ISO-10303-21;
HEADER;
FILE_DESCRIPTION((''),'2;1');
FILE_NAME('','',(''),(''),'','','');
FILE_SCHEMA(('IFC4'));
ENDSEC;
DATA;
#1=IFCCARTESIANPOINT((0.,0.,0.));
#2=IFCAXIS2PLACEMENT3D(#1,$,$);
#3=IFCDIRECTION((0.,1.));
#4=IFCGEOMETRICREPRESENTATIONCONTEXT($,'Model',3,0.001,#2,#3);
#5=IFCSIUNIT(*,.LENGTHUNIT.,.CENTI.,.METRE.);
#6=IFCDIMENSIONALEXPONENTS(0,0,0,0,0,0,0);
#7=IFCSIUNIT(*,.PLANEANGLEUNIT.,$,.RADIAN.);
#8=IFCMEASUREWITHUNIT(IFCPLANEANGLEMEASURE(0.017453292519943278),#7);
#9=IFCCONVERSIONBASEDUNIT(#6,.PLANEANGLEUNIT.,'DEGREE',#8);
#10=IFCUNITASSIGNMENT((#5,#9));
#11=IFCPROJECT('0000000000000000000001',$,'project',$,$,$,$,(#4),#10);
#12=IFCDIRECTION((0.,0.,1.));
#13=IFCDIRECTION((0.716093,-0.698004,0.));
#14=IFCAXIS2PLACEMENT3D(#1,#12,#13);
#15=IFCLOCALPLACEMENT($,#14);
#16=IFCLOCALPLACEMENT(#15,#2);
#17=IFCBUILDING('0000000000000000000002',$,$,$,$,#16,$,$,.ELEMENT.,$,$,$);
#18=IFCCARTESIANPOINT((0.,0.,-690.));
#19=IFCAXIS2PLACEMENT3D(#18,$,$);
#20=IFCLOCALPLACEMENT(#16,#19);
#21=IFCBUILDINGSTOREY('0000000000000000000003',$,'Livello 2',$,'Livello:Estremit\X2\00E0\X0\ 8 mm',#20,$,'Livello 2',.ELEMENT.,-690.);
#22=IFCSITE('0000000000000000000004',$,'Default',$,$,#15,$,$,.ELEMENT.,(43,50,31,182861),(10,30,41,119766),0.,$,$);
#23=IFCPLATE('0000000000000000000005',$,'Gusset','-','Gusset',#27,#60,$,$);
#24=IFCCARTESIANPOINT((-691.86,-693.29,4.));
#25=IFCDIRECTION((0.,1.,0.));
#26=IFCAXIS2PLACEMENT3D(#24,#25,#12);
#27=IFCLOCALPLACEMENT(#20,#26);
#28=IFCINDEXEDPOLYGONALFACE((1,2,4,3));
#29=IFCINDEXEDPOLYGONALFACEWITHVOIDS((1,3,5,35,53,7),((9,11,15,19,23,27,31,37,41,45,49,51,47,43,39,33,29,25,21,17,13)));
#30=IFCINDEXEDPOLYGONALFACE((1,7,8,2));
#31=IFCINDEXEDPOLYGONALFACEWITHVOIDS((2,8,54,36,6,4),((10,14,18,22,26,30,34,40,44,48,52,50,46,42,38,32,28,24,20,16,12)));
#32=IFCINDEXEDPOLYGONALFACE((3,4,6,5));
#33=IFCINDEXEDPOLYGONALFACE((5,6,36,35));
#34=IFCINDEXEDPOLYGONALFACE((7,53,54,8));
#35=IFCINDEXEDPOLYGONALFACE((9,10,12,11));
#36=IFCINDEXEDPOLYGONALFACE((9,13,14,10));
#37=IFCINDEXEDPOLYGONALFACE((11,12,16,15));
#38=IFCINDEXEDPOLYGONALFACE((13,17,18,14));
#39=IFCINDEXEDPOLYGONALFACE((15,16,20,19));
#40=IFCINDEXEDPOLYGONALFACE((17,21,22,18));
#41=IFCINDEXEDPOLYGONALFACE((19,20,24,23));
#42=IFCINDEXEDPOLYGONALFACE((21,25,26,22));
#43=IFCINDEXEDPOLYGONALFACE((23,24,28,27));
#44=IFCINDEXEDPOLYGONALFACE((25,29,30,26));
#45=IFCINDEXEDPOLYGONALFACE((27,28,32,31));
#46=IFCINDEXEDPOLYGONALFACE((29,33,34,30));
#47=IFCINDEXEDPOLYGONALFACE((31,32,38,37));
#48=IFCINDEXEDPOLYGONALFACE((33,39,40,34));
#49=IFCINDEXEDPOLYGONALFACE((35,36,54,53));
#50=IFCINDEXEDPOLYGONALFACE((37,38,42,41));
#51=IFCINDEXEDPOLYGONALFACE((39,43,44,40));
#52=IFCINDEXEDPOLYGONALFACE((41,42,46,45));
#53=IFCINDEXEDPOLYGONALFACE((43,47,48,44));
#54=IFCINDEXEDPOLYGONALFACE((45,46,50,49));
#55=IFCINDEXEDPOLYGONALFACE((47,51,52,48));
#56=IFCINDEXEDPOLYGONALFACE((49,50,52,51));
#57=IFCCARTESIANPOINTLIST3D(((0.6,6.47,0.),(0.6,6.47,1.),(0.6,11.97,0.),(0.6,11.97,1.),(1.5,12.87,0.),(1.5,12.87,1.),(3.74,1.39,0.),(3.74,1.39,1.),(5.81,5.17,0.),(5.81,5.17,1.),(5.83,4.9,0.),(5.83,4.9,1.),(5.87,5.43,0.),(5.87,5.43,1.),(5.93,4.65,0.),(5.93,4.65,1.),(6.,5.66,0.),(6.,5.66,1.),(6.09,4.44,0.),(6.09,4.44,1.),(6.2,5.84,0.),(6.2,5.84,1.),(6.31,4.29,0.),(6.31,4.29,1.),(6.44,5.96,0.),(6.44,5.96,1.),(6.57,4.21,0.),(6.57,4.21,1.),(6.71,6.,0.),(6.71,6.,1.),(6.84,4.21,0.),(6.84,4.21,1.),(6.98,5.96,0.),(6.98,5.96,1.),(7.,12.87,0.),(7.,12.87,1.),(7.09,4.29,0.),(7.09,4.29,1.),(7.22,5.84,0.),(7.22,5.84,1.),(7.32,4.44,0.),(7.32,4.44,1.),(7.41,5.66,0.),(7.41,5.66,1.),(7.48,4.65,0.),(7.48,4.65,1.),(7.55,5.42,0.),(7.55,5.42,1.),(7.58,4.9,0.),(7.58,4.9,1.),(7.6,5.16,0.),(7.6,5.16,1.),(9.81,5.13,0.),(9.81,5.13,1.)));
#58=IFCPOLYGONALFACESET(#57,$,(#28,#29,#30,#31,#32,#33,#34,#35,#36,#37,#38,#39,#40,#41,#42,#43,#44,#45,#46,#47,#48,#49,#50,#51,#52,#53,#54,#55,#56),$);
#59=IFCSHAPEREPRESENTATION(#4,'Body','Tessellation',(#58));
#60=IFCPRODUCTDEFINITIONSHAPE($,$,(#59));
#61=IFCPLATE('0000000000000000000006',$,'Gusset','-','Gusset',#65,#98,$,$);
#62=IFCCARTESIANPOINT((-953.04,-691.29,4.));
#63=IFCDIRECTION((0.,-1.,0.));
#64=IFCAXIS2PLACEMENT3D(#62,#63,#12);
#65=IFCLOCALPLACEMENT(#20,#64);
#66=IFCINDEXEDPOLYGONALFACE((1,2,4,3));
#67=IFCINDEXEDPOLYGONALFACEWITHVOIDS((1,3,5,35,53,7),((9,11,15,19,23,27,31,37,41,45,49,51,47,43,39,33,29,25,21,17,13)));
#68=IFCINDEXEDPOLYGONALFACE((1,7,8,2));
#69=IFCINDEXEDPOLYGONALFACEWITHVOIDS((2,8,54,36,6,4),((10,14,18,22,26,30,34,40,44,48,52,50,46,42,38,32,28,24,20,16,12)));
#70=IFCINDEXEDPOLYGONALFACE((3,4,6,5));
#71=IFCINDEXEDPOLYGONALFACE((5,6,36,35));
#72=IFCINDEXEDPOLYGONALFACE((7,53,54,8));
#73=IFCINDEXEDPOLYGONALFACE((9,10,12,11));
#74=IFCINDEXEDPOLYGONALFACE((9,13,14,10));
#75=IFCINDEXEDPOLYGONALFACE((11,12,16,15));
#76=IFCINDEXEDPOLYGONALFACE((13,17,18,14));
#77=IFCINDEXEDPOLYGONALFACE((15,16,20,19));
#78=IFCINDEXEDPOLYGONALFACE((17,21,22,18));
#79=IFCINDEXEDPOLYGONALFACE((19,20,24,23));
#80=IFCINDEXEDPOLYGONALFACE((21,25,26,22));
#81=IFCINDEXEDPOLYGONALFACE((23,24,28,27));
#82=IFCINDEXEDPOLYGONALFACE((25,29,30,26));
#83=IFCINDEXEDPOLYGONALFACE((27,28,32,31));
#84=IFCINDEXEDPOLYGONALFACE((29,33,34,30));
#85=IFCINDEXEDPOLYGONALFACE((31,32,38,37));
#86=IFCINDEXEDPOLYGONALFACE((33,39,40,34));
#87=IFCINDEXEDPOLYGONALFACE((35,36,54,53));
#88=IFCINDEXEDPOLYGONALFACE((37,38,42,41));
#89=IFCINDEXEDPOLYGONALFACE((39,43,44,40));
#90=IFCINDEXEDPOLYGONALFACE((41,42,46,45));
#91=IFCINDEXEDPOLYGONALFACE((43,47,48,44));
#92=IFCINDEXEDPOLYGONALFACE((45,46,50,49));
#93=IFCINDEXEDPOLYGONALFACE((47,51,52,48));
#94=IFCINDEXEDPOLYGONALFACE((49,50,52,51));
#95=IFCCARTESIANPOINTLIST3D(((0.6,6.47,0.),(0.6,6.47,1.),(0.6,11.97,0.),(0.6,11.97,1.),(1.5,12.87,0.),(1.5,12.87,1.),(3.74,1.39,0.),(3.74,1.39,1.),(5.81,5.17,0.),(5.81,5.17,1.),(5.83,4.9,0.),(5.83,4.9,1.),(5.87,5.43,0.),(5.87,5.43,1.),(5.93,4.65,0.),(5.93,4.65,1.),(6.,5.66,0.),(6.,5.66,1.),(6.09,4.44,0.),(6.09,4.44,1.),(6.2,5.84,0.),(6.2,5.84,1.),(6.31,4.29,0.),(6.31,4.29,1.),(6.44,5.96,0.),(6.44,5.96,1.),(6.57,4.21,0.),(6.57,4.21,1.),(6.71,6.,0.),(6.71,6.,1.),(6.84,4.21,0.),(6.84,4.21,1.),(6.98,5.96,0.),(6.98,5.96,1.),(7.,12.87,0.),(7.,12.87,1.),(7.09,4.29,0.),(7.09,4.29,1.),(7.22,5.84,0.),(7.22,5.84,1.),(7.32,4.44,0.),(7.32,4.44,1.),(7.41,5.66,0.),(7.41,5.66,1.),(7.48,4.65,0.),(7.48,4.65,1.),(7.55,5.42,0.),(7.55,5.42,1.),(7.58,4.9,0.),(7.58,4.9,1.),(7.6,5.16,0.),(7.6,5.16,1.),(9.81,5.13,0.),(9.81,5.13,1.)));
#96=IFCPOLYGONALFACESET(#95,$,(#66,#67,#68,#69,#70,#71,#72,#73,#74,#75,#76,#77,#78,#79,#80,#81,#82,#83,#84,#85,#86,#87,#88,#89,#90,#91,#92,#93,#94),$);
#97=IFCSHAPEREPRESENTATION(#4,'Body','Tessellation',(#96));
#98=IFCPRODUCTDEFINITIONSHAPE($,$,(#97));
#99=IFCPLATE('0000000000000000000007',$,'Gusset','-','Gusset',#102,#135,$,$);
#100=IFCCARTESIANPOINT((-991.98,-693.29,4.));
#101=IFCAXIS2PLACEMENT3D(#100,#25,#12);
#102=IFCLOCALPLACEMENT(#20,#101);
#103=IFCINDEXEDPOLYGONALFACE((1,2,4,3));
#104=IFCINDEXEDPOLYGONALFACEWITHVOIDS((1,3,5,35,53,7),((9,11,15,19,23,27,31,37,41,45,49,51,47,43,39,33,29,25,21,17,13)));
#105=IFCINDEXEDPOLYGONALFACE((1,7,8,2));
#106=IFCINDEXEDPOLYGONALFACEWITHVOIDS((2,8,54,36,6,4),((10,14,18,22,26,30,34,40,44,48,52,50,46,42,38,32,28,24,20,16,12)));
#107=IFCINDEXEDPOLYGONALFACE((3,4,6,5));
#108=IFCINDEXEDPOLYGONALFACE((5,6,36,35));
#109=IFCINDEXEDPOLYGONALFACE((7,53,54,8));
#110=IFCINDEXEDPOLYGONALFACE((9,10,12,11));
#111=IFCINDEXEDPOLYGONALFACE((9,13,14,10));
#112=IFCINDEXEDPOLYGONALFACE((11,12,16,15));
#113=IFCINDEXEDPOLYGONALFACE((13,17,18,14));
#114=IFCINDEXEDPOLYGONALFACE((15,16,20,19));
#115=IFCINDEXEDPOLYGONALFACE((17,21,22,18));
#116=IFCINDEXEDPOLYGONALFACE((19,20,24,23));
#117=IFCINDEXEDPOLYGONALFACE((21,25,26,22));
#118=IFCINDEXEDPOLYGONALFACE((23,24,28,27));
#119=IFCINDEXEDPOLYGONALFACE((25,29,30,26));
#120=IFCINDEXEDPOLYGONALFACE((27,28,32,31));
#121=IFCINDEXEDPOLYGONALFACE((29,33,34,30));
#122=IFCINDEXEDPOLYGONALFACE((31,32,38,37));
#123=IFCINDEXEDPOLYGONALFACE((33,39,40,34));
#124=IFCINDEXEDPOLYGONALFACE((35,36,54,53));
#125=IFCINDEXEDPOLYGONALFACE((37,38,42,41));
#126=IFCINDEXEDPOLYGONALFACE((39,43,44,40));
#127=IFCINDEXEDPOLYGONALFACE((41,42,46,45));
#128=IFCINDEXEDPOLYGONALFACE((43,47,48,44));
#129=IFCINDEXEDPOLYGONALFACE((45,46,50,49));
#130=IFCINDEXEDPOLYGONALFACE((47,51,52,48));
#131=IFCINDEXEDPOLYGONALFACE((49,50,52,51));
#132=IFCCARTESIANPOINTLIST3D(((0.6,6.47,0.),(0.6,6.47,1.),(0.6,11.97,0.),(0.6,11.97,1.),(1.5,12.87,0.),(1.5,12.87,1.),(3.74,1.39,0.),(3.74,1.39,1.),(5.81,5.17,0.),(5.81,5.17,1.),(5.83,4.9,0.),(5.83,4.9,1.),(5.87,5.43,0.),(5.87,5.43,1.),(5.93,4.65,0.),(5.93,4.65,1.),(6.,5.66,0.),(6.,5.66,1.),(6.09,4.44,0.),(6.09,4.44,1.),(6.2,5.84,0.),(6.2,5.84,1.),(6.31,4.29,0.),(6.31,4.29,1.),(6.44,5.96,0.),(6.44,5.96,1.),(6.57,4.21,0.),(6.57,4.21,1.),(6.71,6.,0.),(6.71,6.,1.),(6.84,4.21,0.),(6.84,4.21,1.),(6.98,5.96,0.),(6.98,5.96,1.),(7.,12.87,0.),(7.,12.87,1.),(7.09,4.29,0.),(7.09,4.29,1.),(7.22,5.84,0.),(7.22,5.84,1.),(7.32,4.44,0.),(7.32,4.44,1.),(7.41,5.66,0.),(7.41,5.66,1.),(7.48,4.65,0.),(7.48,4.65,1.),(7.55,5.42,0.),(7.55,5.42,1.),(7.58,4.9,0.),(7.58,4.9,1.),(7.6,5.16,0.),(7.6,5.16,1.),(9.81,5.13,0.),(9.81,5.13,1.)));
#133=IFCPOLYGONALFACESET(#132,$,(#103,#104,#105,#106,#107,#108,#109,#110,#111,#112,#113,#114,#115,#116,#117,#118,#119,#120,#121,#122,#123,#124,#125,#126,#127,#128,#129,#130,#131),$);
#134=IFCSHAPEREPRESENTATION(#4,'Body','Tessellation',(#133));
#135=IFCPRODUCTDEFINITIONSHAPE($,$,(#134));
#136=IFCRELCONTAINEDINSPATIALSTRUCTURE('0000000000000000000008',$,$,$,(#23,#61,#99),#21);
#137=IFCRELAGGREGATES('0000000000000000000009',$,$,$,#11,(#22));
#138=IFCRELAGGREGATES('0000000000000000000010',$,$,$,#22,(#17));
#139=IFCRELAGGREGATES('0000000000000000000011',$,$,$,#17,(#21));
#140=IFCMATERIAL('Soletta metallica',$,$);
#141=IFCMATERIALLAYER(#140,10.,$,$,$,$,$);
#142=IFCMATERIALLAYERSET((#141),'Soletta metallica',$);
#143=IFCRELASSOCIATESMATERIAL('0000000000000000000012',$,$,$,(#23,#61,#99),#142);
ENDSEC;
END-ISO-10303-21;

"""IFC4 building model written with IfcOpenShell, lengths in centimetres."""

from ifc_helpers import new_model, entity, si_unit, converted_unit, point, direction, frame, frame_2d, origin, origin_with_axes, origin_2d_with_axis, place, context, project, spatial, polyline, circle_curve, line_curve, trimmed, segment, composite_curve, circle, outline, extrude, material, layer, layer_set, element, save


model = new_model("IFC4")

# Units and contexts
model_context = context("Model", 3, precision=0.001, world=origin(), true_north=direction((0.0, 1.0)))
ifc_project = project(units=[si_unit("LENGTHUNIT", "METRE", prefix="CENTI"), converted_unit("PLANEANGLEUNIT", "DEGREE", entity("IfcPlaneAngleMeasure", 0.017453292519943278), si_unit("PLANEANGLEUNIT", "RADIAN"), dimensions=[0, 0, 0, 0, 0, 0, 0])], contexts=[model_context])

# Site, building, storey
site_placement = place(None, frame((0.0, 0.0, 0.0), z_axis=(0.0, 0.0, 1.0), x_axis=(0.716093, -0.698004, 0.0)))
site = spatial("IfcSite", under=ifc_project, at=site_placement, Name="Default", CompositionType="ELEMENT", RefLatitude=(43, 50, 31, 182861), RefLongitude=(10, 30, 41, 119766), RefElevation=0.0)
building_placement = place(site_placement, origin())
building = spatial("IfcBuilding", under=site, at=building_placement, CompositionType="ELEMENT")
storey_placement = place(building_placement, frame((0.0, 0.0, -690.0)))
storey = spatial("IfcBuildingStorey", under=building, at=storey_placement, Name="Livello 2", ObjectType="Livello:Estremità 8 mm", LongName="Livello 2", CompositionType="ELEMENT", Elevation=-690.0)

# Plates, openings
ifc_material_1 = material(Name="Soletta metallica")
ifc_layer = layer(ifc_material_1, 10.0)
ifc_layer_set = layer_set([ifc_layer], Name="Soletta metallica")
plate_1_placement = place(storey_placement, frame((-691.86, -693.29, 4.0), z_axis=(0.0, 1.0, 0.0), x_axis=(0.0, 0.0, 1.0)))
plate_1 = element("IfcPlate", 1, at=plate_1_placement, inside=storey, material=ifc_layer_set, Name="Gusset", Description="-", ObjectType="Gusset", context=model_context, shape_type="SweptSolid", body=[
    extrude(outline(polyline([(0.6, 6.47), (3.74, 1.39), (9.81, 5.13), (7.0, 12.87), (0.6, 12.87), (0.6, 6.47)])), origin_with_axes(), (0.0, 0.0, 1.0), 1.0),
])
opening_1_placement = place(plate_1_placement, frame((0.0, 0.0, 0.0), z_axis=(0.0, 0.0, 1.0), x_axis=(1.0, 0.0, 0.0)))
element("IfcOpeningElement", 2, at=opening_1_placement, cuts=plate_1, ObjectType="Opening", context=model_context, shape_type="SweptSolid", body=[
    extrude(outline(composite_curve([segment(trimmed(line_curve((0.6, 12.87), (0.0, -1.0), 0.9), [point((0.6, 12.87))], [point((0.6, 11.97))], True, "CARTESIAN"), True, "CONTINUOUS"), segment(trimmed(circle_curve(frame_2d((1.5, 11.97), x_axis=(-1.0, 0.0)), 0.9), [point((0.6, 11.97))], [point((1.5, 12.87))], False, "CARTESIAN"), True, "CONTINUOUS"), segment(trimmed(line_curve((1.5, 12.87), (-1.0, 0.0), 0.9), [point((1.5, 12.87))], [point((0.6, 12.87))], True, "CARTESIAN"), True, "CONTINUOUS")], self_intersect="UNKNOWN")), origin(), (0.0, 0.0, 1.0), 1.0),
])
opening_2_placement = place(plate_1_placement, frame((6.71, 5.1, 1.05), z_axis=(0.0, 0.0, -1.0), x_axis=(-0.56027, 0.82831, 0.0)))
element("IfcOpeningElement", 3, at=opening_2_placement, cuts=plate_1, ObjectType="Opening", context=model_context, shape_type="SweptSolid", body=[
    extrude(circle(Radius=0.9, at=origin_2d_with_axis()), origin(), (0.0, 0.0, 1.0), 1.1),
])
plate_2_placement = place(storey_placement, frame((-953.04, -691.29, 4.0), z_axis=(0.0, -1.0, 0.0), x_axis=(0.0, 0.0, 1.0)))
plate_2 = element("IfcPlate", 4, at=plate_2_placement, inside=storey, material=ifc_layer_set, Name="Gusset", Description="-", ObjectType="Gusset", context=model_context, shape_type="SweptSolid", body=[
    extrude(outline(polyline([(0.6, 6.47), (3.74, 1.39), (9.81, 5.13), (7.0, 12.87), (0.6, 12.87), (0.6, 6.47)])), origin_with_axes(), (0.0, 0.0, 1.0), 1.0),
])
opening_3_placement = place(plate_2_placement, frame((0.0, 0.0, 0.0), z_axis=(0.0, 0.0, 1.0), x_axis=(1.0, 0.0, 0.0)))
element("IfcOpeningElement", 5, at=opening_3_placement, cuts=plate_2, ObjectType="Opening", context=model_context, shape_type="SweptSolid", body=[
    extrude(outline(composite_curve([segment(trimmed(line_curve((0.6, 12.87), (0.0, -1.0), 0.9), [point((0.6, 12.87))], [point((0.6, 11.97))], True, "CARTESIAN"), True, "CONTINUOUS"), segment(trimmed(circle_curve(frame_2d((1.5, 11.97), x_axis=(-1.0, 0.0)), 0.9), [point((0.6, 11.97))], [point((1.5, 12.87))], False, "CARTESIAN"), True, "CONTINUOUS"), segment(trimmed(line_curve((1.5, 12.87), (-1.0, 0.0), 0.9), [point((1.5, 12.87))], [point((0.6, 12.87))], True, "CARTESIAN"), True, "CONTINUOUS")], self_intersect="UNKNOWN")), origin(), (0.0, 0.0, 1.0), 1.0),
])
opening_4_placement = place(plate_2_placement, frame((6.71, 5.1, 1.05), z_axis=(0.0, 0.0, -1.0), x_axis=(-0.56027, 0.82831, 0.0)))
element("IfcOpeningElement", 6, at=opening_4_placement, cuts=plate_2, ObjectType="Opening", context=model_context, shape_type="SweptSolid", body=[
    extrude(circle(Radius=0.9, at=origin_2d_with_axis()), origin(), (0.0, 0.0, 1.0), 1.1),
])
plate_3_placement = place(storey_placement, frame((-991.98, -693.29, 4.0), z_axis=(0.0, 1.0, 0.0), x_axis=(0.0, 0.0, 1.0)))
plate_3 = element("IfcPlate", 7, at=plate_3_placement, inside=storey, material=ifc_layer_set, Name="Gusset", Description="-", ObjectType="Gusset", context=model_context, shape_type="SweptSolid", body=[
    extrude(outline(polyline([(0.6, 6.47), (3.74, 1.39), (9.81, 5.13), (7.0, 12.87), (0.6, 12.87), (0.6, 6.47)])), origin_with_axes(), (0.0, 0.0, 1.0), 1.0),
])
opening_5_placement = place(plate_3_placement, frame((0.0, 0.0, 0.0), z_axis=(0.0, 0.0, 1.0), x_axis=(1.0, 0.0, 0.0)))
element("IfcOpeningElement", 8, at=opening_5_placement, cuts=plate_3, ObjectType="Opening", context=model_context, shape_type="SweptSolid", body=[
    extrude(outline(composite_curve([segment(trimmed(line_curve((0.6, 12.87), (0.0, -1.0), 0.9), [point((0.6, 12.87))], [point((0.6, 11.97))], True, "CARTESIAN"), True, "CONTINUOUS"), segment(trimmed(circle_curve(frame_2d((1.5, 11.97), x_axis=(-1.0, 0.0)), 0.9), [point((0.6, 11.97))], [point((1.5, 12.87))], False, "CARTESIAN"), True, "CONTINUOUS"), segment(trimmed(line_curve((1.5, 12.87), (-1.0, 0.0), 0.9), [point((1.5, 12.87))], [point((0.6, 12.87))], True, "CARTESIAN"), True, "CONTINUOUS")], self_intersect="UNKNOWN")), origin(), (0.0, 0.0, 1.0), 1.0),
])
opening_6_placement = place(plate_3_placement, frame((6.71, 5.1, 1.05), z_axis=(0.0, 0.0, -1.0), x_axis=(-0.56027, 0.82831, 0.0)))
element("IfcOpeningElement", 9, at=opening_6_placement, cuts=plate_3, ObjectType="Opening", context=model_context, shape_type="SweptSolid", body=[
    extrude(circle(Radius=0.9, at=origin_2d_with_axis()), origin(), (0.0, 0.0, 1.0), 1.1),
])

save(model, "model.ifc")
